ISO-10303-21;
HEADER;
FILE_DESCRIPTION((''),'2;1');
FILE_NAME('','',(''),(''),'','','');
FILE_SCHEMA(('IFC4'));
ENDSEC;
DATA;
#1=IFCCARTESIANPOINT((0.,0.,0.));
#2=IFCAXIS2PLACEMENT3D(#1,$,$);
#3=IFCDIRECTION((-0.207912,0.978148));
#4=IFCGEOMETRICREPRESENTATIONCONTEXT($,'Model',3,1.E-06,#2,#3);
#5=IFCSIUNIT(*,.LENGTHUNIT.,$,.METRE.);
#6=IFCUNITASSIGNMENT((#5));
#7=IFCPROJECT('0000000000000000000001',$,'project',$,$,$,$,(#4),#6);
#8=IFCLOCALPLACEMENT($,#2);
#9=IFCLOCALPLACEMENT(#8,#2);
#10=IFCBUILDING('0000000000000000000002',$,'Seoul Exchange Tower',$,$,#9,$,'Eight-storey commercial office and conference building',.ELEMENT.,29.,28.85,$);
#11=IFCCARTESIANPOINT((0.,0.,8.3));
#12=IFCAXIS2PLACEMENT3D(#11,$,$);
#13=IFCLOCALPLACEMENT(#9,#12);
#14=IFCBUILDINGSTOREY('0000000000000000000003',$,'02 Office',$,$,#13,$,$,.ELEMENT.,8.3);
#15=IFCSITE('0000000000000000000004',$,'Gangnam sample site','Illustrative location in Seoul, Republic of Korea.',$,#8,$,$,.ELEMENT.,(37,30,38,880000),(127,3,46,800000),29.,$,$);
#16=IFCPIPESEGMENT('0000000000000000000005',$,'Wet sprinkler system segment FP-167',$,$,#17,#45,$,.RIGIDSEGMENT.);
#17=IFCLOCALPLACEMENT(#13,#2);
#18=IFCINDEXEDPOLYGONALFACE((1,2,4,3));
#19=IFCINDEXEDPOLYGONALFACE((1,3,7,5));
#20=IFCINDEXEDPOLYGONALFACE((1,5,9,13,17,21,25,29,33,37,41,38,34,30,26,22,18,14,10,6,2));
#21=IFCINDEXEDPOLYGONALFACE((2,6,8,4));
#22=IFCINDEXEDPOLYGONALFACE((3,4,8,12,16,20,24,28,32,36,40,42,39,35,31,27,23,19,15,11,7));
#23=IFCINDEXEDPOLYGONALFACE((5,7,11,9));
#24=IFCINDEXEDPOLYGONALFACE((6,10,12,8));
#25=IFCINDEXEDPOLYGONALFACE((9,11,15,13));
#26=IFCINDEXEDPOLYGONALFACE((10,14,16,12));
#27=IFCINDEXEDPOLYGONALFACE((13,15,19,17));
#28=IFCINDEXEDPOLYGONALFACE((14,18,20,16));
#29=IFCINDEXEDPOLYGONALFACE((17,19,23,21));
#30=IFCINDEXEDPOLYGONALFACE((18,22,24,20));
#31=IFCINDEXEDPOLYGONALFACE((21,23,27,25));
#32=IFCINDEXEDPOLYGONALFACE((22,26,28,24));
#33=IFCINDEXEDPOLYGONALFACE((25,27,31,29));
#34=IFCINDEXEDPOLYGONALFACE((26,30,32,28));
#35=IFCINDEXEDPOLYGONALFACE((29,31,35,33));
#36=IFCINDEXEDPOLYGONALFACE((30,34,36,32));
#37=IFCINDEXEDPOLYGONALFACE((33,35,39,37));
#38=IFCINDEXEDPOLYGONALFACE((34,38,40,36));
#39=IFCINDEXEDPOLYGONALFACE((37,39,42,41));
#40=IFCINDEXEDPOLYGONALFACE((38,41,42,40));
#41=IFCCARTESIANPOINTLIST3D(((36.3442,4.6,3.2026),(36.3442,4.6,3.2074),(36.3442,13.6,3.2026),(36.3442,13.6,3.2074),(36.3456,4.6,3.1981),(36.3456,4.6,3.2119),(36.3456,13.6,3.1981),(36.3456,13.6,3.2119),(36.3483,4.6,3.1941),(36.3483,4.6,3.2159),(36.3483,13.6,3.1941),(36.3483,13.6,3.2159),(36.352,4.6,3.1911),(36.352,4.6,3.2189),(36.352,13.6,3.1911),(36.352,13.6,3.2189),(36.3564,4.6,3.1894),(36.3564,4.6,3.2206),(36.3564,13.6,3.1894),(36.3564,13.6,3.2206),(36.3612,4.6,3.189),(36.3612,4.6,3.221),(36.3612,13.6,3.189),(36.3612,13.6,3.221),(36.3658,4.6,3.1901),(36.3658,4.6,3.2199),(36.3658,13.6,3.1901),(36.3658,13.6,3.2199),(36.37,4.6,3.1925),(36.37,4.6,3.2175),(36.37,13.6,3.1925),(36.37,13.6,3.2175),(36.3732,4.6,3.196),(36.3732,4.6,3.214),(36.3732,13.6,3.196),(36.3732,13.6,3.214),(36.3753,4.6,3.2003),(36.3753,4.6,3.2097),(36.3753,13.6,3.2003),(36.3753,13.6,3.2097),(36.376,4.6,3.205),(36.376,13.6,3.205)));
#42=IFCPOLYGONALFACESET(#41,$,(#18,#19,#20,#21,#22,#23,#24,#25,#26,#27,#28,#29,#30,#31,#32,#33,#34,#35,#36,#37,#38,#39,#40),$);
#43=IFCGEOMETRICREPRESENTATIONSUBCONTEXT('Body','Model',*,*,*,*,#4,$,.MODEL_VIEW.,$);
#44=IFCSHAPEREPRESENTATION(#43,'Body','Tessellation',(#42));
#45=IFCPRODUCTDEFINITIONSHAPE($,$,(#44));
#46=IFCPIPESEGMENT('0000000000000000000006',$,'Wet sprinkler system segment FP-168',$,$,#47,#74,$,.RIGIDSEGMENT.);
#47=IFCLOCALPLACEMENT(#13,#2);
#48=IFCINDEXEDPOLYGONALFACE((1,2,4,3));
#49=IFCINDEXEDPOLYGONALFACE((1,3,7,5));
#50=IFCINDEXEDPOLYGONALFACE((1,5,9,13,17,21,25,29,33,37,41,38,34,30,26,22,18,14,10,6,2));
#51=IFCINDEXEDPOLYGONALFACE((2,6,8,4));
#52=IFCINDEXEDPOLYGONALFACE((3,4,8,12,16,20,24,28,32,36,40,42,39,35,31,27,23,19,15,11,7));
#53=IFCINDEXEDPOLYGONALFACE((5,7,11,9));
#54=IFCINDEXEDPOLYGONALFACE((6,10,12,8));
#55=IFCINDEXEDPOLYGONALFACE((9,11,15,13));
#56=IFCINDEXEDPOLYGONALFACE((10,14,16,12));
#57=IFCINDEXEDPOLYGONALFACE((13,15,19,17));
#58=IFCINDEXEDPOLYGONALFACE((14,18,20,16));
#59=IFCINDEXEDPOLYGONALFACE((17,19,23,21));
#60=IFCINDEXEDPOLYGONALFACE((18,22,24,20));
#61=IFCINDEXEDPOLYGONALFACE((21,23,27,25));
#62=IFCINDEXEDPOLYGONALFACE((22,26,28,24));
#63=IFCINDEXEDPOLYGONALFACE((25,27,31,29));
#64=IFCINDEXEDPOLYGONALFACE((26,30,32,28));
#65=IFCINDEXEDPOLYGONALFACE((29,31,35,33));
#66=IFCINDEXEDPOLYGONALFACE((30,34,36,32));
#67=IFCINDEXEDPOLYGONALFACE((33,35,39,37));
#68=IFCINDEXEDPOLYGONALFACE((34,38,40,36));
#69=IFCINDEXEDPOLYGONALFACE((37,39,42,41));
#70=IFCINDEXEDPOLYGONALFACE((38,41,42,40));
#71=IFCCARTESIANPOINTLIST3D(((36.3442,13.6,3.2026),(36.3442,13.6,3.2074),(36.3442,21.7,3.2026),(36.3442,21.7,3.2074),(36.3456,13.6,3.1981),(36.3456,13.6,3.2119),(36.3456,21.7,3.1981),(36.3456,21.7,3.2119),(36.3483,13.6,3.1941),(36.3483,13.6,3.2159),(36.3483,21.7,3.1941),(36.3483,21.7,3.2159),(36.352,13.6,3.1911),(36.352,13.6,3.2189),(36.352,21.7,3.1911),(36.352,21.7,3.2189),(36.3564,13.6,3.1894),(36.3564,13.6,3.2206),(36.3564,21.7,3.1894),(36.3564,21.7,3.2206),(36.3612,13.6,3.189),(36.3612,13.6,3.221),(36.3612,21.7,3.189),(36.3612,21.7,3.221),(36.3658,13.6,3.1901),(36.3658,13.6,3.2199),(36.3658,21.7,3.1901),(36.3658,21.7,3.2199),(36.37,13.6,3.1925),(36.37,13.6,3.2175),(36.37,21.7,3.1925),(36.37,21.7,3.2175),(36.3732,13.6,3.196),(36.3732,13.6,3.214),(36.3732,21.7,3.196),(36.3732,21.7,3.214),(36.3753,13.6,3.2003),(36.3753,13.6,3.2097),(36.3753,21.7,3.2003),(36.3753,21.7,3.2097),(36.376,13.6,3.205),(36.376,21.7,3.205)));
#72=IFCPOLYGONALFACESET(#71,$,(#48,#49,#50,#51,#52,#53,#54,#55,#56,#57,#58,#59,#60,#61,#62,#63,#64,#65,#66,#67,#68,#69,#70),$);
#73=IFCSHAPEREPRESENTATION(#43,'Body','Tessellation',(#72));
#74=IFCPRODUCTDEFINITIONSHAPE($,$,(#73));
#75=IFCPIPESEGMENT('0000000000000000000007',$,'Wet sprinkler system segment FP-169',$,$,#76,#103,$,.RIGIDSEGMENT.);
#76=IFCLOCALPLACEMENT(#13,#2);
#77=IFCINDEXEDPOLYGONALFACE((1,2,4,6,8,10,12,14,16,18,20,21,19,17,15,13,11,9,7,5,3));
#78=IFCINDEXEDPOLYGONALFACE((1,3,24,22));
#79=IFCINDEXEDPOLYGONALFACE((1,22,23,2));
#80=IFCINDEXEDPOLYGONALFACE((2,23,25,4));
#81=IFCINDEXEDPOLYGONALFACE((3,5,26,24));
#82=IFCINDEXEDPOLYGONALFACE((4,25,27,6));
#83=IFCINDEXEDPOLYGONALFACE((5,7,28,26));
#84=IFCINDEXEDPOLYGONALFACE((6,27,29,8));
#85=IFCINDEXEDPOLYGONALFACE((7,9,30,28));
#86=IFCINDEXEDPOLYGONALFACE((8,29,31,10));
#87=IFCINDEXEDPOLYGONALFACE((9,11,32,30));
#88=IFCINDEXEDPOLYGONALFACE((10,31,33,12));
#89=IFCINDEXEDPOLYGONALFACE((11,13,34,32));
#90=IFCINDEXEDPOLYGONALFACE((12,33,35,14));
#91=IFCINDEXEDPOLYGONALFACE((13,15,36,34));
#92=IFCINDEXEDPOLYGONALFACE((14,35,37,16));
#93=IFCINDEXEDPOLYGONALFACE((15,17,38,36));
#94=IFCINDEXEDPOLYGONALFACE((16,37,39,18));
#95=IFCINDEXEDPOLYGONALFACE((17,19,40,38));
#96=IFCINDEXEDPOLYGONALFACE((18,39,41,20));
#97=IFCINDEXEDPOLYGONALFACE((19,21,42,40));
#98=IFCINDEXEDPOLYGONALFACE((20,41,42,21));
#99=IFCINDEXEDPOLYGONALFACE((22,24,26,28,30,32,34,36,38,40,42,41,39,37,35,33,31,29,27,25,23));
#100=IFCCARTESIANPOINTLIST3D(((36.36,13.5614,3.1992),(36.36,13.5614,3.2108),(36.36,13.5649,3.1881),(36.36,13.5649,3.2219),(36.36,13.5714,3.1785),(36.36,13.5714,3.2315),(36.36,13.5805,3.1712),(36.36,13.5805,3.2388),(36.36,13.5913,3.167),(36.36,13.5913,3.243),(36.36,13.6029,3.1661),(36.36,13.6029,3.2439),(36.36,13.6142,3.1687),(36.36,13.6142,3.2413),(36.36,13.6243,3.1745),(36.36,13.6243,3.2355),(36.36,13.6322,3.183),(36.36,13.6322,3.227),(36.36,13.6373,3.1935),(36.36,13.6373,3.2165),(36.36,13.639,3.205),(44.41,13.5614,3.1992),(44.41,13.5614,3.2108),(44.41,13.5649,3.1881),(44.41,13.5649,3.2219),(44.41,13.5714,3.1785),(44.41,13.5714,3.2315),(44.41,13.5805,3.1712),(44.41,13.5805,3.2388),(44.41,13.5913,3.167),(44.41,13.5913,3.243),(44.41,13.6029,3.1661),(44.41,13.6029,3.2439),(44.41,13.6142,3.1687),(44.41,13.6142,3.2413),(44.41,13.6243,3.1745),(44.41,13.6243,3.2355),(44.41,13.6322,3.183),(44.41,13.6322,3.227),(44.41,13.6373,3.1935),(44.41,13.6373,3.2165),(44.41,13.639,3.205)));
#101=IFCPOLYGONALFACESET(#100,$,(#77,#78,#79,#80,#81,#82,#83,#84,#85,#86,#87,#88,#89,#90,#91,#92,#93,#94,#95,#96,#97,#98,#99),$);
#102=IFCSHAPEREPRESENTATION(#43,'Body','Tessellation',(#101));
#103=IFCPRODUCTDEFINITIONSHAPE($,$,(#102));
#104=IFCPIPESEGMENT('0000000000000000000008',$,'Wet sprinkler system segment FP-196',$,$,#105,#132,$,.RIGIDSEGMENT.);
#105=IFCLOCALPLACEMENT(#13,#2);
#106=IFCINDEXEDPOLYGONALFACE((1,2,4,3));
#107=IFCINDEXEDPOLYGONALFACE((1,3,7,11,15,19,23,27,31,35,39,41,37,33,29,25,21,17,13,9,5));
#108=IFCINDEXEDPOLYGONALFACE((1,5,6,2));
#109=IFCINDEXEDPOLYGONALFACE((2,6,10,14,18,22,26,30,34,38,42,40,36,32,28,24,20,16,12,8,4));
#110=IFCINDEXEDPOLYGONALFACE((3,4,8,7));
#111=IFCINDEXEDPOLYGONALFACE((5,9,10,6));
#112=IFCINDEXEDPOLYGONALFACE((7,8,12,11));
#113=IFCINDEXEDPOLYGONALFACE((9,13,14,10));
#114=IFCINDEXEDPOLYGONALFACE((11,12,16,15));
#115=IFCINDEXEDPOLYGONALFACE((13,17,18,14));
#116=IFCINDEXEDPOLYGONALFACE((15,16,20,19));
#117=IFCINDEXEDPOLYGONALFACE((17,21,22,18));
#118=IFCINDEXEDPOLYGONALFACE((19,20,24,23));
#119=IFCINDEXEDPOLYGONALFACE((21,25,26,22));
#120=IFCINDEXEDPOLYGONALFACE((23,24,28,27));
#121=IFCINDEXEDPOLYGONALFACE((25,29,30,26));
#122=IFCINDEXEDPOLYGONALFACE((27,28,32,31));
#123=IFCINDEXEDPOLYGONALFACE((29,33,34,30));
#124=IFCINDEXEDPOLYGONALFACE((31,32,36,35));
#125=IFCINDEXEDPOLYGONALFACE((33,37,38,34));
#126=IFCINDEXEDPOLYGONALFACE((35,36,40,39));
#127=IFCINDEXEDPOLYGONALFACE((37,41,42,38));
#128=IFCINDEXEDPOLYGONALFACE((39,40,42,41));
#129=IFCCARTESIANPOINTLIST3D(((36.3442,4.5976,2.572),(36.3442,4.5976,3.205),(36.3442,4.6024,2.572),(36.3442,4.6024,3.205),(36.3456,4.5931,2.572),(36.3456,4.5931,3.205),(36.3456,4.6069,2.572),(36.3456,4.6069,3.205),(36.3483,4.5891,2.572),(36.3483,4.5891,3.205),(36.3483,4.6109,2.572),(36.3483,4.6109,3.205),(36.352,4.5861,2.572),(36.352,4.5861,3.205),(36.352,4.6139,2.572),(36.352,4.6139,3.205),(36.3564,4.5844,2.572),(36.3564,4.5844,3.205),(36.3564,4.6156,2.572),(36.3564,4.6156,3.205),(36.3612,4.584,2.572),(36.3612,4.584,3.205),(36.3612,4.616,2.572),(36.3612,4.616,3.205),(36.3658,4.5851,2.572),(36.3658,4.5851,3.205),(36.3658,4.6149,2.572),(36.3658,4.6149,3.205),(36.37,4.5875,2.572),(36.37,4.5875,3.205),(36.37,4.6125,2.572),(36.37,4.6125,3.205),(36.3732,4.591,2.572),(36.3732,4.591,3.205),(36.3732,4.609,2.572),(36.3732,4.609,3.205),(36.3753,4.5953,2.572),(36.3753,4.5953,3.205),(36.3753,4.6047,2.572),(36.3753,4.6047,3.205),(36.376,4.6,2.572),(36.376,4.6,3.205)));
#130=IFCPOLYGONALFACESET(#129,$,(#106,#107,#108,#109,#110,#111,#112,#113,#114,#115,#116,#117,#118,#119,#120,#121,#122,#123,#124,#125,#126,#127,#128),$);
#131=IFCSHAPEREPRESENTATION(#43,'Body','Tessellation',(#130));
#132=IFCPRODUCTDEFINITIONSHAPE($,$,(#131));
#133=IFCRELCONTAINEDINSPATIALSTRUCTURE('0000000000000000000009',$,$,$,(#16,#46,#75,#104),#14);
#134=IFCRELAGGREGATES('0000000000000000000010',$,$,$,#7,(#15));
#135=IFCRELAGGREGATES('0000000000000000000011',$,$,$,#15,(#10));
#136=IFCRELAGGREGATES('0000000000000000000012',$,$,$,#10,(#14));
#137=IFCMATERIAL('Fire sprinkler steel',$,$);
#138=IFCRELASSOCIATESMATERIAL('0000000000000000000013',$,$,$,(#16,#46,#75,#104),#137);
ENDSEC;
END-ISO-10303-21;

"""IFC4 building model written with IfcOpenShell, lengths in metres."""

from ifc_helpers import new_model, si_unit, direction, frame, origin, place, context, subcontext, project, spatial, circle, extrude, material, element, save


model = new_model("IFC4")

# Units and contexts
model_context = context("Model", 3, precision=1e-06, world=origin(), true_north=direction((-0.207912, 0.978148)))
body_context = subcontext(model_context, "Body", "Model", "MODEL_VIEW")
ifc_project = project(units=[si_unit("LENGTHUNIT", "METRE")], contexts=[model_context])

# Site, building, storey
site_placement = place(None, origin())
site = spatial("IfcSite", under=ifc_project, at=site_placement, Name="Gangnam sample site", Description="Illustrative location in Seoul, Republic of Korea.", CompositionType="ELEMENT", RefLatitude=(37, 30, 38, 880000), RefLongitude=(127, 3, 46, 800000), RefElevation=29.0)
building_placement = place(site_placement, origin())
building = spatial("IfcBuilding", under=site, at=building_placement, Name="Seoul Exchange Tower", LongName="Eight-storey commercial office and conference building", CompositionType="ELEMENT", ElevationOfRefHeight=29.0, ElevationOfTerrain=28.85)
storey_placement = place(building_placement, frame((0.0, 0.0, 8.3)))
storey = spatial("IfcBuildingStorey", under=building, at=storey_placement, Name="02 Office", CompositionType="ELEMENT", Elevation=8.3)

# Shared definitions
ifc_material = material(Name="Fire sprinkler steel")
placement = place(storey_placement, origin())

# Pipe segments
element("IfcPipeSegment", 1, at=placement, inside=storey, material=ifc_material, Name="Wet sprinkler system segment FP-167", PredefinedType="RIGIDSEGMENT", context=body_context, shape_type="SweptSolid", body=[
    extrude(circle(Radius=0.016), frame((36.36, 13.6, 3.205), z_axis=(0.0, -1.0, 0.0), x_axis=(1.0, 0.0, 0.0)), (0.0, 0.0, 1.0), 9.0),
])
element("IfcPipeSegment", 2, at=placement, inside=storey, material=ifc_material, Name="Wet sprinkler system segment FP-168", PredefinedType="RIGIDSEGMENT", context=body_context, shape_type="SweptSolid", body=[
    extrude(circle(Radius=0.016), frame((36.36, 13.6, 3.205), z_axis=(0.0, 1.0, 0.0), x_axis=(1.0, 0.0, 0.0)), (0.0, 0.0, 1.0), 8.1),
])
element("IfcPipeSegment", 3, at=placement, inside=storey, material=ifc_material, Name="Wet sprinkler system segment FP-169", PredefinedType="RIGIDSEGMENT", context=body_context, shape_type="SweptSolid", body=[
    extrude(circle(Radius=0.039), frame((36.36, 13.6, 3.205), z_axis=(1.0, 0.0, 0.0), x_axis=(0.0, 1.0, 0.0)), (0.0, 0.0, 1.0), 8.05),
])
element("IfcPipeSegment", 4, at=placement, inside=storey, material=ifc_material, Name="Wet sprinkler system segment FP-196", PredefinedType="RIGIDSEGMENT", context=body_context, shape_type="SweptSolid", body=[
    extrude(circle(Radius=0.016), frame((36.36, 4.6, 3.205), z_axis=(0.0, 0.0, -1.0), x_axis=(1.0, 0.0, 0.0)), (0.0, 0.0, 1.0), 0.633),
])

save(model, "model.ifc")
